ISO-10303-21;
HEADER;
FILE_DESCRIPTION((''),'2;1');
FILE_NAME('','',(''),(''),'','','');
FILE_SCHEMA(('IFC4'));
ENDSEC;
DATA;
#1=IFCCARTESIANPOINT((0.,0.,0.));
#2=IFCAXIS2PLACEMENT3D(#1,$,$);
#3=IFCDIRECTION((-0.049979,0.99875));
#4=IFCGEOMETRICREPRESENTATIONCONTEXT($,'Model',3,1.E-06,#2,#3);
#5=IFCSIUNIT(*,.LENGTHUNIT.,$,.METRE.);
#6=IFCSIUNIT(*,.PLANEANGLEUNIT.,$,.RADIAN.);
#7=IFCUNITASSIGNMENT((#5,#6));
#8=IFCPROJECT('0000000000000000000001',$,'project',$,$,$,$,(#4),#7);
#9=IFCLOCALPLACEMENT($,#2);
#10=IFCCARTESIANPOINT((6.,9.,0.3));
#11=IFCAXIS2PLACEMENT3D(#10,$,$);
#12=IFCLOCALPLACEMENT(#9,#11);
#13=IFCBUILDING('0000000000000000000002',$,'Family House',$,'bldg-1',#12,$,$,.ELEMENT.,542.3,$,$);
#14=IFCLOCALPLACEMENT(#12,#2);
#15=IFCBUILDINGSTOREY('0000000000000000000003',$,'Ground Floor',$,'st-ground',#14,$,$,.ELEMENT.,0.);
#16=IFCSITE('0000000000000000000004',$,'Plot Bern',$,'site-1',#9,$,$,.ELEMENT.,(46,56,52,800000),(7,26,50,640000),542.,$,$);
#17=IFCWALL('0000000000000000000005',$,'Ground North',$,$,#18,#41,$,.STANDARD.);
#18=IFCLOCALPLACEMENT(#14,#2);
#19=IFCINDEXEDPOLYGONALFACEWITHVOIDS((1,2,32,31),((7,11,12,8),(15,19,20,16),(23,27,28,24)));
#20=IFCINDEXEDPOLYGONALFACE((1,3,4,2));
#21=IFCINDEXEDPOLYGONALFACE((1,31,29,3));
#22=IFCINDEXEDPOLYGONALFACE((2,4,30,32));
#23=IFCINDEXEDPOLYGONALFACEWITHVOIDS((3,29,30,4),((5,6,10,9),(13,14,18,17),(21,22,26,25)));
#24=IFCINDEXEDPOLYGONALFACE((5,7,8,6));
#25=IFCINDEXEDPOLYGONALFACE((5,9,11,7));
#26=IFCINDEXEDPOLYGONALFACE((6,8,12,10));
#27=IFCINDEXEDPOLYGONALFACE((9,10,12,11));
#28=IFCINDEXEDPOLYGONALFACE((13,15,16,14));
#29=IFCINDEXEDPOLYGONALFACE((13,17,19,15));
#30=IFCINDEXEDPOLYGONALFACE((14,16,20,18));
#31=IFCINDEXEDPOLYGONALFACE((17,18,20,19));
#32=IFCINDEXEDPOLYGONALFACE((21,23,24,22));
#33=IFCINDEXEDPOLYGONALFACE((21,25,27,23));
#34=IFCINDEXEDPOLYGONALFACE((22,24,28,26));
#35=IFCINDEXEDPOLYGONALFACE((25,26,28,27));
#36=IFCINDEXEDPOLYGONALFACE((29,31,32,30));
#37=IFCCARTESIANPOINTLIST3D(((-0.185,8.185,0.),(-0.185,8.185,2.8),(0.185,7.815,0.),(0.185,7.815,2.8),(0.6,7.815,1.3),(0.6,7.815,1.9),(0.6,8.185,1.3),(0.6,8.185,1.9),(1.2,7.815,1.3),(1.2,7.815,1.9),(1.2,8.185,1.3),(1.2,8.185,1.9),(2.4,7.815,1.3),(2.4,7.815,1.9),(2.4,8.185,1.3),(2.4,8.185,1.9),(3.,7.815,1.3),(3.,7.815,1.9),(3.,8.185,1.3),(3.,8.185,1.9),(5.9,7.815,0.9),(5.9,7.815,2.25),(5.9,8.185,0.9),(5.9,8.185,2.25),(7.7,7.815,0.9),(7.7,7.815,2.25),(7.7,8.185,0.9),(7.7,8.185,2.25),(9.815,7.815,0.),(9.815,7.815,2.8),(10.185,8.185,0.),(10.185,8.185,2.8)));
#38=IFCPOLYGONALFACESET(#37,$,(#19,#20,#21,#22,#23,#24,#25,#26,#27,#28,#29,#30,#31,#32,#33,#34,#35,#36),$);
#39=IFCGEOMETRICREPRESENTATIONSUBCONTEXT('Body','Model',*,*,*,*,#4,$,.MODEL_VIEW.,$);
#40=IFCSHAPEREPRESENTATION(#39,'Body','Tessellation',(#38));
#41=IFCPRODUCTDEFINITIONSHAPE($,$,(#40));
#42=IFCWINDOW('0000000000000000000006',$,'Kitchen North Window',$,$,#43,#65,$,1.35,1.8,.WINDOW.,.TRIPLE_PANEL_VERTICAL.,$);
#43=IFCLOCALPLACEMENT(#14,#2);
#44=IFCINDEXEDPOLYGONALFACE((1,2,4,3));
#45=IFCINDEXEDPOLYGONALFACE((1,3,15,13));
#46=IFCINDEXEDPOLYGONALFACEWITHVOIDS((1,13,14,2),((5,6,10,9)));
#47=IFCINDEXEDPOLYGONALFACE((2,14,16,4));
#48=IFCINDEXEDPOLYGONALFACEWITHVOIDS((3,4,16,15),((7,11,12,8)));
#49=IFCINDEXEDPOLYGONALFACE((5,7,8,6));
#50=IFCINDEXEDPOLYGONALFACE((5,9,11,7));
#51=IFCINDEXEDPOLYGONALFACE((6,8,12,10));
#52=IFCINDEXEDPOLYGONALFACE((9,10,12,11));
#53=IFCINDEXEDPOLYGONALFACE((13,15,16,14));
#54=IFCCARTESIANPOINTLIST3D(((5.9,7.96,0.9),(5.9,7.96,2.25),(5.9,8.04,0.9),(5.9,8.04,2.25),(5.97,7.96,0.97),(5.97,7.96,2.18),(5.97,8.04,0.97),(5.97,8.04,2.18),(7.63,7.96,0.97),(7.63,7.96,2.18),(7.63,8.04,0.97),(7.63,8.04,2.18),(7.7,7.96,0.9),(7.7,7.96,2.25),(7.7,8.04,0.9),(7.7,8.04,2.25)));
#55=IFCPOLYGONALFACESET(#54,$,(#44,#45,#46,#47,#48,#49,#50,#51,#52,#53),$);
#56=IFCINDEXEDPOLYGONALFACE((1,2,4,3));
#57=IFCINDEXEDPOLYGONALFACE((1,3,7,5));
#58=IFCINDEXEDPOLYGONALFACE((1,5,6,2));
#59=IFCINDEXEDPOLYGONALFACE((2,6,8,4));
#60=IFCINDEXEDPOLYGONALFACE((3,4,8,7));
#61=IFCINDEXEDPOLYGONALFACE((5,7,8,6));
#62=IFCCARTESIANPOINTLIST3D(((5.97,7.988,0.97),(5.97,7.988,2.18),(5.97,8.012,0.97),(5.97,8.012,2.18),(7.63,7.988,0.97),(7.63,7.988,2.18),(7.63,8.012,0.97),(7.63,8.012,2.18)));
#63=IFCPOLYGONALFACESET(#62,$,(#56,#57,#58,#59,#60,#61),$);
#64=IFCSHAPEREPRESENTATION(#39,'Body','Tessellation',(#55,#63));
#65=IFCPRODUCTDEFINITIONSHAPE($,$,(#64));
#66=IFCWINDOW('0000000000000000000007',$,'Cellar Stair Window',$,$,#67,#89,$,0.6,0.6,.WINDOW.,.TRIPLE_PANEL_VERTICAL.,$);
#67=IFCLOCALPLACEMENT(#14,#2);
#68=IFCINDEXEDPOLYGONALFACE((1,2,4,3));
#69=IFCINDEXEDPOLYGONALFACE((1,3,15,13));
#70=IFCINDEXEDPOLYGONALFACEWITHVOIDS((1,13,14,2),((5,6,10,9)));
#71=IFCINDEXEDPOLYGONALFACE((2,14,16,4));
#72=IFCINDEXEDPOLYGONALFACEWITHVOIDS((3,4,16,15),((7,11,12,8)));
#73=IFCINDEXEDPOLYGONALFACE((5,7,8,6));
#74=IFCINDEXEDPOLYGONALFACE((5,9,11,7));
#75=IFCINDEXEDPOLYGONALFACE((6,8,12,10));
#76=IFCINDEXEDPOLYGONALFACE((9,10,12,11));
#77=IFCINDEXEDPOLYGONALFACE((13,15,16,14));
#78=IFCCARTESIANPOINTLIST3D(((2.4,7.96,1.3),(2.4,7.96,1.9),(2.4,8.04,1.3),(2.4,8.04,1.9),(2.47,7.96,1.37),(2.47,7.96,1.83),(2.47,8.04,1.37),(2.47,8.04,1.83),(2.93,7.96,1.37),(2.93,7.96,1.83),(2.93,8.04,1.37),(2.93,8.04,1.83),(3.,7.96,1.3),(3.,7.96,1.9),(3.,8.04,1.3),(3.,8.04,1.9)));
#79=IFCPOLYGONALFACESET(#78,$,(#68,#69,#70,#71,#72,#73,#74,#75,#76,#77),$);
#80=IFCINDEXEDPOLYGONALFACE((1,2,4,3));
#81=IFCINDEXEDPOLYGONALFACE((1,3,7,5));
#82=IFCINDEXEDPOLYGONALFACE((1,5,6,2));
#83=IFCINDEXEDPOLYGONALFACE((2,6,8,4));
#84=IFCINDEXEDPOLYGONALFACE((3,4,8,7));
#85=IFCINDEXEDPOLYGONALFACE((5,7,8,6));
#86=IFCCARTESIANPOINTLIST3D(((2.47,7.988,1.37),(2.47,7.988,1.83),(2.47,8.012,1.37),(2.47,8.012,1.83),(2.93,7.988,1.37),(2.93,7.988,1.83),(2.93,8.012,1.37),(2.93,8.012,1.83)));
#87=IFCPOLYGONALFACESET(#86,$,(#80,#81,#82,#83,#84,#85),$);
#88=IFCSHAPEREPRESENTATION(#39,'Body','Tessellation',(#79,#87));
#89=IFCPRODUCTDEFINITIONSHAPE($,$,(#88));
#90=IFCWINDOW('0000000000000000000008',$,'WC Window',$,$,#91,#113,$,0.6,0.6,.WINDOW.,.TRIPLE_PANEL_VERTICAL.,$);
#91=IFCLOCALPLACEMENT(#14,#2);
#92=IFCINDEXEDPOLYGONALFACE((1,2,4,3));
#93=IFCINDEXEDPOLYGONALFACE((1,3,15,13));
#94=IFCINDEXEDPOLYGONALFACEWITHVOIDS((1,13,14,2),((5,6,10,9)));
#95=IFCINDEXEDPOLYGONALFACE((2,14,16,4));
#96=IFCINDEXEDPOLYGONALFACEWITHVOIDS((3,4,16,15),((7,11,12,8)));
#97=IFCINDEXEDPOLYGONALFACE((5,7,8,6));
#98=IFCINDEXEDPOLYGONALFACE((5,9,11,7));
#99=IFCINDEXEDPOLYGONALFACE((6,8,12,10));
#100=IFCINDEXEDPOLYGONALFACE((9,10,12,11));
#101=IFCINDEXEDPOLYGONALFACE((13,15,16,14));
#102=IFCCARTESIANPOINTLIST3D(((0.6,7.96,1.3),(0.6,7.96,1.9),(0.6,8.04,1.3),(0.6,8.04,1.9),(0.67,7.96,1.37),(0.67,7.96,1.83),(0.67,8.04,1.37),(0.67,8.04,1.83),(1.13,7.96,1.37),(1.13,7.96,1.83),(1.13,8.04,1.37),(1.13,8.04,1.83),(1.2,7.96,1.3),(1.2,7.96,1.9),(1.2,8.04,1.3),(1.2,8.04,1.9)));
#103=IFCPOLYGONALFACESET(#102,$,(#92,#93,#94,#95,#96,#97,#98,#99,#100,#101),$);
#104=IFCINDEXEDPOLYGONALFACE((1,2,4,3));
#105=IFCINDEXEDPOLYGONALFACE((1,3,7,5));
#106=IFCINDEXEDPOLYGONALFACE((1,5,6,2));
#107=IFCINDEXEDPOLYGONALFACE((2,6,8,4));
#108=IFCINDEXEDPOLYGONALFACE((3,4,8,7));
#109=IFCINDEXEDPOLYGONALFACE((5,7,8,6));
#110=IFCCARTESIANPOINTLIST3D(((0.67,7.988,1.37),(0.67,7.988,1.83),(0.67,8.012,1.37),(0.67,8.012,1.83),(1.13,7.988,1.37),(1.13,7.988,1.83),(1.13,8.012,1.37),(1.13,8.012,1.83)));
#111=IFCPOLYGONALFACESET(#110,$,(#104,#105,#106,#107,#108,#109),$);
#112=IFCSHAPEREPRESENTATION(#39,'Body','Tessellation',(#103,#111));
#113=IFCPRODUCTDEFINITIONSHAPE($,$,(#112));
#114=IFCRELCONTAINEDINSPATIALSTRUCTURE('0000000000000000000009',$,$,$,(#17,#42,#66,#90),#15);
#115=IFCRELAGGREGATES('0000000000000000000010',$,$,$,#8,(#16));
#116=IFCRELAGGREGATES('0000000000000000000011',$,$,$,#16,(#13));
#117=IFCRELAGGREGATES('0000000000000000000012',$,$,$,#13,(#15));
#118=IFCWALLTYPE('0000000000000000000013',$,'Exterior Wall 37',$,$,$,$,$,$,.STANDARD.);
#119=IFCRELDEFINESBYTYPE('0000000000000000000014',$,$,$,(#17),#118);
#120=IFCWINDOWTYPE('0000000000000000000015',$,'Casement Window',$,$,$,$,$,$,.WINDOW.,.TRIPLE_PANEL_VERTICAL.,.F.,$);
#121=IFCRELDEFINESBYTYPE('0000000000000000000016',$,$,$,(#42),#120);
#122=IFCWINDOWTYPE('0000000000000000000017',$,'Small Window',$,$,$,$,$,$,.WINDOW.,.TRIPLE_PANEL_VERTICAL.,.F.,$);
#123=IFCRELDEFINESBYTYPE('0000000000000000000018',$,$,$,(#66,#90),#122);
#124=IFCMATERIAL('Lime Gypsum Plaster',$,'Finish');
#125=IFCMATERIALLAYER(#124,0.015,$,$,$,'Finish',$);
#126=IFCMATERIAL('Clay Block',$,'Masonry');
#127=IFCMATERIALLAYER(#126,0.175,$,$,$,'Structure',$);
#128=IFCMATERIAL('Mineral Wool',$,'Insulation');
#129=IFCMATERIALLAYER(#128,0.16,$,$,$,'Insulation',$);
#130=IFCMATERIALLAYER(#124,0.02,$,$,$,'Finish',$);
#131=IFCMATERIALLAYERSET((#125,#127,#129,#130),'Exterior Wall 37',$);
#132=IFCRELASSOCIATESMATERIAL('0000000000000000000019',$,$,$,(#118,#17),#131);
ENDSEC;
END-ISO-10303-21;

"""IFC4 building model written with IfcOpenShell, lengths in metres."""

from ifc_helpers import new_model, si_unit, direction, frame, frame_2d, origin, origin_2d, place, context, subcontext, project, spatial, polyline, rectangle, outline, extrude, material, layer, layer_set, layer_usage, type_object, element, fill, save


model = new_model("IFC4")

# Units and contexts
model_context = context("Model", 3, precision=1e-06, world=origin(), true_north=direction((-0.049979, 0.99875)))
body_context = subcontext(model_context, "Body", "Model", "MODEL_VIEW")
ifc_project = project(units=[si_unit("LENGTHUNIT", "METRE"), si_unit("PLANEANGLEUNIT", "RADIAN")], contexts=[model_context])

# Site, building, storey
site_placement = place(None, origin())
site = spatial("IfcSite", under=ifc_project, at=site_placement, Name="Plot Bern", ObjectType="site-1", CompositionType="ELEMENT", RefLatitude=(46, 56, 52, 800000), RefLongitude=(7, 26, 50, 640000), RefElevation=542.0)
building_placement = place(site_placement, frame((6.0, 9.0, 0.3)))
building = spatial("IfcBuilding", under=site, at=building_placement, Name="Family House", ObjectType="bldg-1", CompositionType="ELEMENT", ElevationOfRefHeight=542.3)
storey_placement = place(building_placement, origin())
storey = spatial("IfcBuildingStorey", under=building, at=storey_placement, Name="Ground Floor", ObjectType="st-ground", CompositionType="ELEMENT", Elevation=0.0)

# Shared definitions
ifc_material_1 = material(Name="Mineral Wool", Category="Insulation")

# Shared definitions
ifc_material_2 = material(Name="Lime Gypsum Plaster", Category="Finish")
ifc_layer_1 = layer(ifc_material_2, 0.015, Category="Finish")
ifc_material_3 = material(Name="Clay Block", Category="Masonry")
ifc_layer_2 = layer(ifc_material_3, 0.175, Category="Structure")
ifc_layer_3 = layer(ifc_material_1, 0.16, Category="Insulation")
ifc_layer_4 = layer(ifc_material_2, 0.02, Category="Finish")
ifc_layer_set_1 = layer_set([ifc_layer_1, ifc_layer_2, ifc_layer_3, ifc_layer_4], Name="Exterior Wall 37")
wall_type_1 = type_object("IfcWallType", Name="Exterior Wall 37", PredefinedType="STANDARD", material=ifc_layer_set_1)

# Shared definitions
window_type_1 = type_object("IfcWindowType", Name="Casement Window", ParameterTakesPrecedence=False, PartitioningType="TRIPLE_PANEL_VERTICAL", PredefinedType="WINDOW")

# Wall, openings, windows
ifc_layer_usage_1 = layer_usage(ifc_layer_set_1, "AXIS2", "NEGATIVE", 0.185)
wall_1_placement = place(storey_placement, origin())
wall_1 = element("IfcWall", 1, at=wall_1_placement, inside=storey, type_object=wall_type_1, material=ifc_layer_usage_1, Name="Ground North", PredefinedType="STANDARD", context=body_context, shape_type="SweptSolid", body=[
    extrude(outline(polyline([(10.185, 8.185), (-0.185, 8.185), (0.185, 7.815), (9.815, 7.815), (10.185, 8.185)])), origin(), (0.0, 0.0, 1.0), 2.8),
])
opening_1_placement = place(wall_1_placement, frame((2.7, 8.0, 1.3), z_axis=(0.0, 0.0, 1.0), x_axis=(-1.0, 0.0, 0.0)))
opening_1 = element("IfcOpeningElement", 2, at=opening_1_placement, cuts=wall_1, PredefinedType="OPENING", context=body_context, shape_type="SweptSolid", body=[
    extrude(rectangle(XDim=0.6, YDim=0.37, at=origin_2d()), origin(), (0.0, 0.0, 1.0), 0.6),
])
opening_2_placement = place(wall_1_placement, frame((6.8, 8.0, 0.9), z_axis=(0.0, 0.0, 1.0), x_axis=(-1.0, 0.0, 0.0)))
opening_2 = element("IfcOpeningElement", 3, at=opening_2_placement, cuts=wall_1, PredefinedType="OPENING", context=body_context, shape_type="SweptSolid", body=[
    extrude(rectangle(XDim=1.8, YDim=0.37, at=origin_2d()), origin(), (0.0, 0.0, 1.0), 1.35),
])
opening_3_placement = place(wall_1_placement, frame((0.9, 8.0, 1.3), z_axis=(0.0, 0.0, 1.0), x_axis=(-1.0, 0.0, 0.0)))
opening_3 = element("IfcOpeningElement", 4, at=opening_3_placement, cuts=wall_1, PredefinedType="OPENING", context=body_context, shape_type="SweptSolid", body=[
    extrude(rectangle(XDim=0.6, YDim=0.37, at=origin_2d()), origin(), (0.0, 0.0, 1.0), 0.6),
])
window_1_placement = place(opening_2_placement, frame((0.0, 0.0, 0.0), z_axis=(0.0, -1.0, 0.0), x_axis=(1.0, 0.0, 0.0)))
window_1 = element("IfcWindow", 5, at=window_1_placement, inside=storey, type_object=window_type_1, Name="Kitchen North Window", OverallHeight=1.35, OverallWidth=1.8, PartitioningType="TRIPLE_PANEL_VERTICAL", PredefinedType="WINDOW", context=body_context, shape_type="SweptSolid", body=[
    extrude(outline(polyline([(-0.9, 0.0), (0.9, 0.0), (0.9, 1.35), (-0.9, 1.35), (-0.9, 0.0)]), holes=[polyline([(-0.83, 0.07), (0.83, 0.07), (0.83, 1.28), (-0.83, 1.28), (-0.83, 0.07)])]), frame((0.0, 0.0, -0.04)), (0.0, 0.0, 1.0), 0.08),
    extrude(rectangle(XDim=1.66, YDim=1.21, at=frame_2d((0.0, 0.675))), frame((0.0, 0.0, -0.012)), (0.0, 0.0, 1.0), 0.024),
])
fill(opening_2, window_1)
window_type_2 = type_object("IfcWindowType", Name="Small Window", ParameterTakesPrecedence=False, PartitioningType="TRIPLE_PANEL_VERTICAL", PredefinedType="WINDOW")
window_2_placement = place(opening_1_placement, frame((0.0, 0.0, 0.0), z_axis=(0.0, -1.0, 0.0), x_axis=(1.0, 0.0, 0.0)))
window_2 = element("IfcWindow", 6, at=window_2_placement, inside=storey, type_object=window_type_2, Name="Cellar Stair Window", OverallHeight=0.6, OverallWidth=0.6, PartitioningType="TRIPLE_PANEL_VERTICAL", PredefinedType="WINDOW", context=body_context, shape_type="SweptSolid", body=[
    extrude(outline(polyline([(-0.3, 0.0), (0.3, 0.0), (0.3, 0.6), (-0.3, 0.6), (-0.3, 0.0)]), holes=[polyline([(-0.23, 0.07), (0.23, 0.07), (0.23, 0.53), (-0.23, 0.53), (-0.23, 0.07)])]), frame((0.0, 0.0, -0.04)), (0.0, 0.0, 1.0), 0.08),
    extrude(rectangle(XDim=0.46, YDim=0.46, at=frame_2d((0.0, 0.3))), frame((0.0, 0.0, -0.012)), (0.0, 0.0, 1.0), 0.024),
])
fill(opening_1, window_2)
window_3_placement = place(opening_3_placement, frame((0.0, 0.0, 0.0), z_axis=(0.0, -1.0, 0.0), x_axis=(1.0, 0.0, 0.0)))
window_3 = element("IfcWindow", 7, at=window_3_placement, inside=storey, type_object=window_type_2, Name="WC Window", OverallHeight=0.6, OverallWidth=0.6, PartitioningType="TRIPLE_PANEL_VERTICAL", PredefinedType="WINDOW", context=body_context, shape_type="SweptSolid", body=[
    extrude(outline(polyline([(-0.3, 0.0), (0.3, 0.0), (0.3, 0.6), (-0.3, 0.6), (-0.3, 0.0)]), holes=[polyline([(-0.23, 0.07), (0.23, 0.07), (0.23, 0.53), (-0.23, 0.53), (-0.23, 0.07)])]), frame((0.0, 0.0, -0.04)), (0.0, 0.0, 1.0), 0.08),
    extrude(rectangle(XDim=0.46, YDim=0.46, at=frame_2d((0.0, 0.3))), frame((0.0, 0.0, -0.012)), (0.0, 0.0, 1.0), 0.024),
])
fill(opening_3, window_3)

save(model, "model.ifc")
